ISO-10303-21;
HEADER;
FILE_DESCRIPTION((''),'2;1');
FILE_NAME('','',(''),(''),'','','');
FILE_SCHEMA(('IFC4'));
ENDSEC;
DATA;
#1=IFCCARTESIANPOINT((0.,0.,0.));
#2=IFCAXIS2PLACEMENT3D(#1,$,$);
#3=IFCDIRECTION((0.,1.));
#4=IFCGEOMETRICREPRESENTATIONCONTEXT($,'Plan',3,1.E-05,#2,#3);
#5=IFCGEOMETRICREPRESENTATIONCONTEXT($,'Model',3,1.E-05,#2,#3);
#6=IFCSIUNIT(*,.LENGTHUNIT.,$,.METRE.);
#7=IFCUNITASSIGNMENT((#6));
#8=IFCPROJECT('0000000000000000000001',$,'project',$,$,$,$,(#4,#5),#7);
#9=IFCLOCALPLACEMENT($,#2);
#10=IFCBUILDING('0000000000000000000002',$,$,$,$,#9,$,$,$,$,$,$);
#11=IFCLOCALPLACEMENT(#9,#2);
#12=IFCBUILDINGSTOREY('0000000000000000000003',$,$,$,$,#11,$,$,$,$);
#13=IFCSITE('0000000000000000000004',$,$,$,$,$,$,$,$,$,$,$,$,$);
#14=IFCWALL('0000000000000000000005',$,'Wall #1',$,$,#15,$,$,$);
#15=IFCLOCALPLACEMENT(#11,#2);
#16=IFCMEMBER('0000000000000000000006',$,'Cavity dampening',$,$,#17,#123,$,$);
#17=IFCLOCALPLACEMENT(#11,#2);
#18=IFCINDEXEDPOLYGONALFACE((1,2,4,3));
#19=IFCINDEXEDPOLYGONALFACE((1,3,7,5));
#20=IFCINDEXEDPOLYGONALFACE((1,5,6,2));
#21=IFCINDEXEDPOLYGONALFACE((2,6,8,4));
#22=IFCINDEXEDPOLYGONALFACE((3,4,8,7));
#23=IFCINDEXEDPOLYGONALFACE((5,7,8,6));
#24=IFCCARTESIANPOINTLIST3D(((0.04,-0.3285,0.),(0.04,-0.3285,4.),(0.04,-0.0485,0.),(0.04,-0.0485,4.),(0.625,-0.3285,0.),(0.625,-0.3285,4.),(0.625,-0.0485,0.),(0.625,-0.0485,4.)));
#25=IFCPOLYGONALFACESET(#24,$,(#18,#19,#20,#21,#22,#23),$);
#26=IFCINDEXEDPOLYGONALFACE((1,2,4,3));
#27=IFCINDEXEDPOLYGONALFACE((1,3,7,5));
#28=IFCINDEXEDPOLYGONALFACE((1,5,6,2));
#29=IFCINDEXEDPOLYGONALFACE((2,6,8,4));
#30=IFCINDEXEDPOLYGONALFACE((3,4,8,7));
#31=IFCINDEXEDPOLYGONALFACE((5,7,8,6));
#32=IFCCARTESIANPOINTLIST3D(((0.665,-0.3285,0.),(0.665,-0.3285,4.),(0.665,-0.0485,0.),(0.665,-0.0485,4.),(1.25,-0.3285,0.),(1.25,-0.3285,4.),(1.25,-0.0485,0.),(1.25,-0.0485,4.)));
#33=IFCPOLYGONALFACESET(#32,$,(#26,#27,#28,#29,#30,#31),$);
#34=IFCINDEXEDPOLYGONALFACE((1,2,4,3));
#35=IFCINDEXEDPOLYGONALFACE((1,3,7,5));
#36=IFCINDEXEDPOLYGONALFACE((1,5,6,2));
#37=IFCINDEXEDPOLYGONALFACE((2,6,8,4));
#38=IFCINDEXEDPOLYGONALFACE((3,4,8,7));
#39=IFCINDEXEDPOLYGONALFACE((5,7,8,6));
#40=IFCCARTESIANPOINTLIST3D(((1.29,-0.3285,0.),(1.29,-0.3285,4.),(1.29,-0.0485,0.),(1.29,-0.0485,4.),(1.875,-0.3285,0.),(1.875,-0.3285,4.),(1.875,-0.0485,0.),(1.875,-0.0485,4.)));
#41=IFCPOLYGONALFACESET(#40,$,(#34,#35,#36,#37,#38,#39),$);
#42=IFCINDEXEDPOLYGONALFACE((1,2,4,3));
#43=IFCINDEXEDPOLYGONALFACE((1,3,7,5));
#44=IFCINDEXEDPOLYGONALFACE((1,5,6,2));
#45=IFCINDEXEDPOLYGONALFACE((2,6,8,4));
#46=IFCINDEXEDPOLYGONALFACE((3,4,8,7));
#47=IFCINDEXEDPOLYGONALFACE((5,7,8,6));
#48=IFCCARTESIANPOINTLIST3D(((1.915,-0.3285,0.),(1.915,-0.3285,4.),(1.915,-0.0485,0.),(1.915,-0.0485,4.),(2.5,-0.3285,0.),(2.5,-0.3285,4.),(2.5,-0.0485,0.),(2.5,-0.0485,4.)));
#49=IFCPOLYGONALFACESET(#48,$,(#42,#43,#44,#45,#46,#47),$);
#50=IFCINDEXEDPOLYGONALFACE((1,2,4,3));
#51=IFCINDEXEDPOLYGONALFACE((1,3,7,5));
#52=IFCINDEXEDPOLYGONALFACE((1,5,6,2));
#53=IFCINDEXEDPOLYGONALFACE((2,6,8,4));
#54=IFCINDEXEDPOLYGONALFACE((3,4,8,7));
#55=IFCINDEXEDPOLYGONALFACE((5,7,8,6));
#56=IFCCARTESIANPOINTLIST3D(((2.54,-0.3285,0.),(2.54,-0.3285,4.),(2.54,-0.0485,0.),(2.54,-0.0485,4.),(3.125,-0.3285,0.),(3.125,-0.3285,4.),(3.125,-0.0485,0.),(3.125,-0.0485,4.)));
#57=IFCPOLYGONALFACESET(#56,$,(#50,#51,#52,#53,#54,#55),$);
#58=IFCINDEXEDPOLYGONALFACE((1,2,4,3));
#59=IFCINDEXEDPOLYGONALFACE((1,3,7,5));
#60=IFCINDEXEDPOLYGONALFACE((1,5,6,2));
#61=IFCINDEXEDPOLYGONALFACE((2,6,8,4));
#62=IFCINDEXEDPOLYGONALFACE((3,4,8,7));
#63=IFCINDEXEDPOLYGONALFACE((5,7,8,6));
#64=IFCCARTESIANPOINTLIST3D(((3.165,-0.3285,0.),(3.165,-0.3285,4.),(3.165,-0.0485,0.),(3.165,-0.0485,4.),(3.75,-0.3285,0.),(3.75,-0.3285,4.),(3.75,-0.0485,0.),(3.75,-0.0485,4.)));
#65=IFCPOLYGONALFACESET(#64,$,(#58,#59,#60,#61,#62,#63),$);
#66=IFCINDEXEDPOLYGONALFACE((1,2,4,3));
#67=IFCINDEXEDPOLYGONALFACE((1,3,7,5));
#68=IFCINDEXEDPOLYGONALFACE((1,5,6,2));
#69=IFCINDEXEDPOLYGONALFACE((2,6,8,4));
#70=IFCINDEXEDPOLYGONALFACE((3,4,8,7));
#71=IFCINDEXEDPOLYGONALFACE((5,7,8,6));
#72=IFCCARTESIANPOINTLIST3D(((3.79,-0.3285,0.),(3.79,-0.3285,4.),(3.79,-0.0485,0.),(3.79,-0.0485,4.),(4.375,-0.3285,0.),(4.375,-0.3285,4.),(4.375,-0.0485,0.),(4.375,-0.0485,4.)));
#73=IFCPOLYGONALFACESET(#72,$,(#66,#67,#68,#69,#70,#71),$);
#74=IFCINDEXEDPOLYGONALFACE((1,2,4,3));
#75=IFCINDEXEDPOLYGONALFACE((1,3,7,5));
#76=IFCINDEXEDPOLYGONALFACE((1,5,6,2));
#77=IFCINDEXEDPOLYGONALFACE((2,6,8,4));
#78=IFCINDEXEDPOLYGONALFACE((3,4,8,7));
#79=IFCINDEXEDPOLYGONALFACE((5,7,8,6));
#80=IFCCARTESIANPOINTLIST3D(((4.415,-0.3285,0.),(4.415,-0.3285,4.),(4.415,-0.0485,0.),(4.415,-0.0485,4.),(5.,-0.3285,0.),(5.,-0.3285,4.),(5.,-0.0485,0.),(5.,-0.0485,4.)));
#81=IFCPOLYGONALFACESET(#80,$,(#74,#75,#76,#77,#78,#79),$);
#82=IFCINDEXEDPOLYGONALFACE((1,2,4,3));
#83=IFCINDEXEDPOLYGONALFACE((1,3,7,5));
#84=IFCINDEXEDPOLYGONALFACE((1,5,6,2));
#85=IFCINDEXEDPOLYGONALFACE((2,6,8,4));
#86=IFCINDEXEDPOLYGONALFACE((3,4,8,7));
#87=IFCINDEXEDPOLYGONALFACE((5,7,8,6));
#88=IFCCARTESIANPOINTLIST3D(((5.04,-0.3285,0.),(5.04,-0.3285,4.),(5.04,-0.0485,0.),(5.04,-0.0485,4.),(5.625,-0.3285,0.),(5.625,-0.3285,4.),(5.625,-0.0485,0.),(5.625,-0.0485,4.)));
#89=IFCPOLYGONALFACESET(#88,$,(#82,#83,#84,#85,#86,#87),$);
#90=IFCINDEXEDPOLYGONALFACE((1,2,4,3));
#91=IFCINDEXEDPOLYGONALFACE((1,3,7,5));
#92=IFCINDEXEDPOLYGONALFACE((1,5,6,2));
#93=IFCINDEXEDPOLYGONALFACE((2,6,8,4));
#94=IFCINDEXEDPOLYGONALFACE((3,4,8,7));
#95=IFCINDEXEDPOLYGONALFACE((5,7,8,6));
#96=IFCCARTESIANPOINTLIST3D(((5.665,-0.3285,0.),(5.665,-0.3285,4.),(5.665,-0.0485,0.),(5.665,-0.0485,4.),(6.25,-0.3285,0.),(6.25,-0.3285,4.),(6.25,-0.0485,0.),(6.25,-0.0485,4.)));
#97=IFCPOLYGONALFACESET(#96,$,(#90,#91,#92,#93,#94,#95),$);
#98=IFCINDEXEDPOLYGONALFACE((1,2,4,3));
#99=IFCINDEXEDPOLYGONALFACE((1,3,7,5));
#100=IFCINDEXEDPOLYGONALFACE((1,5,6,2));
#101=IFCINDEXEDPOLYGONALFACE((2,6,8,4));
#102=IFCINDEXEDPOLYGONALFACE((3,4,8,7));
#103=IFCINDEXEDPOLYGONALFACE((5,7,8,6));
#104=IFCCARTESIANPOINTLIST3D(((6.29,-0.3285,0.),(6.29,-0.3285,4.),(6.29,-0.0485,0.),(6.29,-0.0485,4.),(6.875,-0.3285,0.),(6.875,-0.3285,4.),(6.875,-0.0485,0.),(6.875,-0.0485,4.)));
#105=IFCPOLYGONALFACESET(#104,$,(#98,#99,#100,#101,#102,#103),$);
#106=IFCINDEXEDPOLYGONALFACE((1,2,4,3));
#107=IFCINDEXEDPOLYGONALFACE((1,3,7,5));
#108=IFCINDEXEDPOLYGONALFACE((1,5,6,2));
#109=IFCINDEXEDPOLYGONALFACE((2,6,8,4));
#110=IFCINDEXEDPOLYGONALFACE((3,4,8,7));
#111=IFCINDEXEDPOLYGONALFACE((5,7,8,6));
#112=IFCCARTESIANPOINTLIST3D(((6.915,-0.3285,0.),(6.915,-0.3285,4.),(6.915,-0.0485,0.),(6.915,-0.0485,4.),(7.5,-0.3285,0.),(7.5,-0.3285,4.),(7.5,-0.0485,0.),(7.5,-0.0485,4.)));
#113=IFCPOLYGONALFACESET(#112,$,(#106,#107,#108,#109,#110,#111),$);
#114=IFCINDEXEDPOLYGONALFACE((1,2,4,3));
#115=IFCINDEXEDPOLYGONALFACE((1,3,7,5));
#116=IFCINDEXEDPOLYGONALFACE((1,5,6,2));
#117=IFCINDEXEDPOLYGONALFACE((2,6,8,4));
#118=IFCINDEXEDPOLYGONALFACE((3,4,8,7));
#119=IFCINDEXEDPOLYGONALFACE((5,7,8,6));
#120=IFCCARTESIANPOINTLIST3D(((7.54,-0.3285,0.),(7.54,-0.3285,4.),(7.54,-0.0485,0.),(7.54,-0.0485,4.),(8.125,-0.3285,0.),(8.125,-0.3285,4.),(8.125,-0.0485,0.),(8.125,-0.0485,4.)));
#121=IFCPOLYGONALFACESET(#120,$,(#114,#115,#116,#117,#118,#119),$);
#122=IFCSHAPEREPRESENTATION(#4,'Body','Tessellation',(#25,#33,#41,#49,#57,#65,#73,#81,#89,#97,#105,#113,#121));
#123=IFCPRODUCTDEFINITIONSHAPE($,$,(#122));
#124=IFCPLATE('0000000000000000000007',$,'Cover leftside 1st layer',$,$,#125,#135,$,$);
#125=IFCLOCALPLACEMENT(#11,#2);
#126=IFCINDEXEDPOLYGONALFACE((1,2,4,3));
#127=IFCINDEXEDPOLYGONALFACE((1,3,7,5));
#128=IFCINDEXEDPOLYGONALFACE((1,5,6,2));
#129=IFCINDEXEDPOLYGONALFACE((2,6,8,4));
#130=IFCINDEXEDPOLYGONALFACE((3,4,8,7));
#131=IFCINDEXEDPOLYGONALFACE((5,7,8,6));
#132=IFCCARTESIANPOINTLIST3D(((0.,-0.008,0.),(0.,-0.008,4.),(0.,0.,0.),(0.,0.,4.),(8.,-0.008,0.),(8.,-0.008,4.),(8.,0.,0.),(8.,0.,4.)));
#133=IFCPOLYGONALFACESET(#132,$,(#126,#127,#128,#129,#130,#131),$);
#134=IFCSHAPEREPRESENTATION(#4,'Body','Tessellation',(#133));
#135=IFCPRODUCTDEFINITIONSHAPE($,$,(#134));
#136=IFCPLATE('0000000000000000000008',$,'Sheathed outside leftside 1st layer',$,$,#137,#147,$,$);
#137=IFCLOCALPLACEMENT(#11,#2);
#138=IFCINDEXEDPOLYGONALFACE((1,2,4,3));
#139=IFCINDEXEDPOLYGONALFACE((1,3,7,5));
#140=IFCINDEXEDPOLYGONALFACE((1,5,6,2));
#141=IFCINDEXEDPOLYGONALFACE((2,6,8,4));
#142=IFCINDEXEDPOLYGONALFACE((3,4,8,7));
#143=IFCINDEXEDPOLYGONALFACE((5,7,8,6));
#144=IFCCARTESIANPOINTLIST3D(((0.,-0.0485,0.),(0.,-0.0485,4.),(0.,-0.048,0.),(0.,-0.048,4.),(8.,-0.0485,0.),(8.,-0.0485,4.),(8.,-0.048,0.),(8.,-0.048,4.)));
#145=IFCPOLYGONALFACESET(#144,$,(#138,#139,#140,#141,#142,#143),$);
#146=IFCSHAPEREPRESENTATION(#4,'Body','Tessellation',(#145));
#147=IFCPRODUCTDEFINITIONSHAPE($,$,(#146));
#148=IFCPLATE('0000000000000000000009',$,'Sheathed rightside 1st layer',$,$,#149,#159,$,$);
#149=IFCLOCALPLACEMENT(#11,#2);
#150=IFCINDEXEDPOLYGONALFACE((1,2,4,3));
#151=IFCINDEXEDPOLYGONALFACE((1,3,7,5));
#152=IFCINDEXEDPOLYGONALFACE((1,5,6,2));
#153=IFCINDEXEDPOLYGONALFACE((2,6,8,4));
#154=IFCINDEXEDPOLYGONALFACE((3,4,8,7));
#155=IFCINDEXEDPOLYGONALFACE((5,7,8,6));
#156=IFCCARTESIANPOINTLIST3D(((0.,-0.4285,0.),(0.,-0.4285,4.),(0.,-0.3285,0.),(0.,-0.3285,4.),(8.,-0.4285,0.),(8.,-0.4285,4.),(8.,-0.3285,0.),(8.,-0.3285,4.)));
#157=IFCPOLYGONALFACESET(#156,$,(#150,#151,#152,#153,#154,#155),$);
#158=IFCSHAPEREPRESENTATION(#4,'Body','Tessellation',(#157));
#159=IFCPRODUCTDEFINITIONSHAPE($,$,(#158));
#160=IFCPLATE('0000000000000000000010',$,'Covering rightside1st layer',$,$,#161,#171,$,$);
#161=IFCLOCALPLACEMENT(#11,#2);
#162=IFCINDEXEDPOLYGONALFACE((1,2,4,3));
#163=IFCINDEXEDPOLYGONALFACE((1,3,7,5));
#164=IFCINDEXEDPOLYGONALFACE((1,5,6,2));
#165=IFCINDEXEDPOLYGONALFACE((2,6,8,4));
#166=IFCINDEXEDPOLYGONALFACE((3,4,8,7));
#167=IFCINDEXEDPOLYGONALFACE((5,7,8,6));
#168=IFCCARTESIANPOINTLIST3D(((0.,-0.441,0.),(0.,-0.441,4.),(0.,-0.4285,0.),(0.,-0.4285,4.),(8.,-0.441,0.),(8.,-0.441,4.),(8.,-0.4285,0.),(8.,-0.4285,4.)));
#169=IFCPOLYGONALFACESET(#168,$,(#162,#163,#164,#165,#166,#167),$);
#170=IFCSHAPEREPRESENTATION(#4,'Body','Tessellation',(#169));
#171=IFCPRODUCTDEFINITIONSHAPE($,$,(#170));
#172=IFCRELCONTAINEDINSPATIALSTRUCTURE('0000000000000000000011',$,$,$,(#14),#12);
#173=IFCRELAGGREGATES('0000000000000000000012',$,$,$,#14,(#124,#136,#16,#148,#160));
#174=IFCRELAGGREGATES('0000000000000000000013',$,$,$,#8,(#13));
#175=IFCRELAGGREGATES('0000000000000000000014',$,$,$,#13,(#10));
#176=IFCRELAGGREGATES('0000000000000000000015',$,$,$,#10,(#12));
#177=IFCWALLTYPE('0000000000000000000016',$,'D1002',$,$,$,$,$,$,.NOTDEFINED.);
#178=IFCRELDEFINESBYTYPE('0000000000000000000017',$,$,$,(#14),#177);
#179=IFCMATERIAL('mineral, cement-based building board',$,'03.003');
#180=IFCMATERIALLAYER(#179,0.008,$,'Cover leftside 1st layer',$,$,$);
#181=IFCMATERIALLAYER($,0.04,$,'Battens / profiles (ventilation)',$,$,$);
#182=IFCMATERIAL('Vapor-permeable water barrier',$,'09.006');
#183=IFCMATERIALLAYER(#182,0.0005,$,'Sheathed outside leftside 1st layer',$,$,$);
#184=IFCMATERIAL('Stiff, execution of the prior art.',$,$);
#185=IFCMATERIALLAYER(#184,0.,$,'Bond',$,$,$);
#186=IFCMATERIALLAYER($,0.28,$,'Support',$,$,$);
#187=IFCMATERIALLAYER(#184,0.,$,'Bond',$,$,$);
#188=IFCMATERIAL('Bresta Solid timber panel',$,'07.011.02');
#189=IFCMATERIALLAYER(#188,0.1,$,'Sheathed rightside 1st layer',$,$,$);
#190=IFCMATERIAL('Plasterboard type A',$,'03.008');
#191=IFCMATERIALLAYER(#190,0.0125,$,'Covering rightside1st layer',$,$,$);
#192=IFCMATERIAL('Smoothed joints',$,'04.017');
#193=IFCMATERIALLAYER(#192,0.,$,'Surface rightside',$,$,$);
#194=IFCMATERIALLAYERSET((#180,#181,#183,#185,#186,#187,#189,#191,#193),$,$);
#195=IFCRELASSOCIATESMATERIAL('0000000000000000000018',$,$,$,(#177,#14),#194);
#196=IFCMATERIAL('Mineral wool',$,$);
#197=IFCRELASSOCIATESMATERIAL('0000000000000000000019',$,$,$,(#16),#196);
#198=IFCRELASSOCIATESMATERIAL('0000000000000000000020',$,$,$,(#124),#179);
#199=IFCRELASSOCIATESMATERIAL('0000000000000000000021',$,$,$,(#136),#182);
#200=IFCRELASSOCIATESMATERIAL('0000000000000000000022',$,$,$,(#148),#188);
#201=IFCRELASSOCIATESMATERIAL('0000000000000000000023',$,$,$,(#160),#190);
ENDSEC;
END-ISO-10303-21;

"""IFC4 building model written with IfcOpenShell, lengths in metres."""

from ifc_helpers import new_model, si_unit, direction, frame, frame_2d, origin, origin_with_axes, place, context, project, spatial, rectangle, extrude, material, layer, layer_set, type_object, element, aggregate, save


model = new_model("IFC4")

# Units and contexts
plan_context = context("Plan", 3, precision=1e-05, world=origin(), true_north=direction((0.0, 1.0)))
model_context = context("Model", 3, precision=1e-05, world=origin(), true_north=direction((0.0, 1.0)))
ifc_project = project(units=[si_unit("LENGTHUNIT", "METRE")], contexts=[plan_context, model_context])

# Site, building, storey
site = spatial("IfcSite", under=ifc_project)
building_placement = place(None, origin())
building = spatial("IfcBuilding", under=site, at=building_placement)
storey_placement = place(building_placement, origin())
storey = spatial("IfcBuildingStorey", under=building, at=storey_placement)

# Wall, member, plates
ifc_material_1 = material(Name="mineral, cement-based building board", Category="03.003")
ifc_layer_1 = layer(ifc_material_1, 0.008, Name="Cover leftside 1st layer")
ifc_layer_2 = layer(None, 0.04, Name="Battens / profiles (ventilation)")
ifc_material_2 = material(Name="Vapor-permeable water barrier", Category="09.006")
ifc_layer_3 = layer(ifc_material_2, 0.0005, Name="Sheathed outside leftside 1st layer")
ifc_material_3 = material(Name="Stiff, execution of the prior art.")
ifc_layer_4 = layer(ifc_material_3, 0.0, Name="Bond")
ifc_layer_5 = layer(None, 0.28, Name="Support")
ifc_layer_6 = layer(ifc_material_3, 0.0, Name="Bond")
ifc_material_4 = material(Name="Bresta Solid timber panel", Category="07.011.02")
ifc_layer_7 = layer(ifc_material_4, 0.1, Name="Sheathed rightside 1st layer")
ifc_material_5 = material(Name="Plasterboard type A", Category="03.008")
ifc_layer_8 = layer(ifc_material_5, 0.0125, Name="Covering rightside1st layer")
ifc_material_6 = material(Name="Smoothed joints", Category="04.017")
ifc_layer_9 = layer(ifc_material_6, 0.0, Name="Surface rightside")
ifc_layer_set = layer_set([ifc_layer_1, ifc_layer_2, ifc_layer_3, ifc_layer_4, ifc_layer_5, ifc_layer_6, ifc_layer_7, ifc_layer_8, ifc_layer_9])
wall_type = type_object("IfcWallType", Name="D1002", PredefinedType="NOTDEFINED", material=ifc_layer_set)
wall_placement = place(None, frame((0.0, 0.0, 0.0), z_axis=(0.0, -1.0, 0.0), x_axis=(1.0, 0.0, 0.0)))
wall = element("IfcWall", 1, at=wall_placement, inside=storey, type_object=wall_type, material=ifc_layer_set, Name="Wall #1")
ifc_material_7 = material(Name="Mineral wool")
member_1_placement = place(wall_placement, origin())
member_1 = element("IfcMember", 2, at=member_1_placement, material=ifc_material_7, Name="Cavity dampening", context=plan_context, shape_type="SweptSolid", body=[
    extrude(rectangle(XDim=0.585, YDim=0.28, at=frame_2d((0.2925, 0.14), x_axis=(1.0, 0.0))), frame((0.04, 4.0, 0.0485), z_axis=(0.0, -1.0, 0.0), x_axis=(1.0, 0.0, 0.0)), (0.0, 0.0, 1.0), 4.0),
    extrude(rectangle(XDim=0.585, YDim=0.28, at=frame_2d((0.2925, 0.14), x_axis=(1.0, 0.0))), frame((0.665, 4.0, 0.0485), z_axis=(0.0, -1.0, 0.0), x_axis=(1.0, 0.0, 0.0)), (0.0, 0.0, 1.0), 4.0),
    extrude(rectangle(XDim=0.585, YDim=0.28, at=frame_2d((0.2925, 0.14), x_axis=(1.0, 0.0))), frame((1.29, 4.0, 0.0485), z_axis=(0.0, -1.0, 0.0), x_axis=(1.0, 0.0, 0.0)), (0.0, 0.0, 1.0), 4.0),
    extrude(rectangle(XDim=0.585, YDim=0.28, at=frame_2d((0.2925, 0.14), x_axis=(1.0, 0.0))), frame((1.915, 4.0, 0.0485), z_axis=(0.0, -1.0, 0.0), x_axis=(1.0, 0.0, 0.0)), (0.0, 0.0, 1.0), 4.0),
    extrude(rectangle(XDim=0.585, YDim=0.28, at=frame_2d((0.2925, 0.14), x_axis=(1.0, 0.0))), frame((2.54, 4.0, 0.0485), z_axis=(0.0, -1.0, 0.0), x_axis=(1.0, 0.0, 0.0)), (0.0, 0.0, 1.0), 4.0),
    extrude(rectangle(XDim=0.585, YDim=0.28, at=frame_2d((0.2925, 0.14), x_axis=(1.0, 0.0))), frame((3.165, 4.0, 0.0485), z_axis=(0.0, -1.0, 0.0), x_axis=(1.0, 0.0, 0.0)), (0.0, 0.0, 1.0), 4.0),
    extrude(rectangle(XDim=0.585, YDim=0.28, at=frame_2d((0.2925, 0.14), x_axis=(1.0, 0.0))), frame((3.79, 4.0, 0.0485), z_axis=(0.0, -1.0, 0.0), x_axis=(1.0, 0.0, 0.0)), (0.0, 0.0, 1.0), 4.0),
    extrude(rectangle(XDim=0.585, YDim=0.28, at=frame_2d((0.2925, 0.14), x_axis=(1.0, 0.0))), frame((4.415, 4.0, 0.0485), z_axis=(0.0, -1.0, 0.0), x_axis=(1.0, 0.0, 0.0)), (0.0, 0.0, 1.0), 4.0),
    extrude(rectangle(XDim=0.585, YDim=0.28, at=frame_2d((0.2925, 0.14), x_axis=(1.0, 0.0))), frame((5.04, 4.0, 0.0485), z_axis=(0.0, -1.0, 0.0), x_axis=(1.0, 0.0, 0.0)), (0.0, 0.0, 1.0), 4.0),
    extrude(rectangle(XDim=0.585, YDim=0.28, at=frame_2d((0.2925, 0.14), x_axis=(1.0, 0.0))), frame((5.665, 4.0, 0.0485), z_axis=(0.0, -1.0, 0.0), x_axis=(1.0, 0.0, 0.0)), (0.0, 0.0, 1.0), 4.0),
    extrude(rectangle(XDim=0.585, YDim=0.28, at=frame_2d((0.2925, 0.14), x_axis=(1.0, 0.0))), frame((6.29, 4.0, 0.0485), z_axis=(0.0, -1.0, 0.0), x_axis=(1.0, 0.0, 0.0)), (0.0, 0.0, 1.0), 4.0),
    extrude(rectangle(XDim=0.585, YDim=0.28, at=frame_2d((0.2925, 0.14), x_axis=(1.0, 0.0))), frame((6.915, 4.0, 0.0485), z_axis=(0.0, -1.0, 0.0), x_axis=(1.0, 0.0, 0.0)), (0.0, 0.0, 1.0), 4.0),
    extrude(rectangle(XDim=0.585, YDim=0.28, at=frame_2d((0.2925, 0.14), x_axis=(1.0, 0.0))), frame((7.54, 4.0, 0.0485), z_axis=(0.0, -1.0, 0.0), x_axis=(1.0, 0.0, 0.0)), (0.0, 0.0, 1.0), 4.0),
])
plate_1_placement = place(wall_placement, origin())
plate_1 = element("IfcPlate", 3, at=plate_1_placement, material=ifc_material_1, Name="Cover leftside 1st layer", context=plan_context, shape_type="SweptSolid", body=[
    extrude(rectangle(XDim=8.0, YDim=4.0, at=frame_2d((4.0, 2.0), x_axis=(1.0, 0.0))), origin_with_axes(), (0.0, 0.0, 1.0), 0.008),
])
plate_2_placement = place(wall_placement, origin())
plate_2 = element("IfcPlate", 4, at=plate_2_placement, material=ifc_material_2, Name="Sheathed outside leftside 1st layer", context=plan_context, shape_type="SweptSolid", body=[
    extrude(rectangle(XDim=8.0, YDim=4.0, at=frame_2d((4.0, 2.0), x_axis=(1.0, 0.0))), frame((0.0, 0.0, 0.048), z_axis=(0.0, 0.0, 1.0), x_axis=(1.0, 0.0, 0.0)), (0.0, 0.0, 1.0), 0.0005),
])
plate_3_placement = place(wall_placement, origin())
plate_3 = element("IfcPlate", 5, at=plate_3_placement, material=ifc_material_4, Name="Sheathed rightside 1st layer", context=plan_context, shape_type="SweptSolid", body=[
    extrude(rectangle(XDim=8.0, YDim=4.0, at=frame_2d((4.0, 2.0), x_axis=(1.0, 0.0))), frame((0.0, 0.0, 0.3285), z_axis=(0.0, 0.0, 1.0), x_axis=(1.0, 0.0, 0.0)), (0.0, 0.0, 1.0), 0.1),
])
plate_4_placement = place(wall_placement, origin())
plate_4 = element("IfcPlate", 6, at=plate_4_placement, material=ifc_material_5, Name="Covering rightside1st layer", context=plan_context, shape_type="SweptSolid", body=[
    extrude(rectangle(XDim=8.0, YDim=4.0, at=frame_2d((4.0, 2.0), x_axis=(1.0, 0.0))), frame((0.0, 0.0, 0.4285), z_axis=(0.0, 0.0, 1.0), x_axis=(1.0, 0.0, 0.0)), (0.0, 0.0, 1.0), 0.0125),
])
aggregate(wall, [plate_1, plate_2, member_1, plate_3, plate_4])

save(model, "model.ifc")
